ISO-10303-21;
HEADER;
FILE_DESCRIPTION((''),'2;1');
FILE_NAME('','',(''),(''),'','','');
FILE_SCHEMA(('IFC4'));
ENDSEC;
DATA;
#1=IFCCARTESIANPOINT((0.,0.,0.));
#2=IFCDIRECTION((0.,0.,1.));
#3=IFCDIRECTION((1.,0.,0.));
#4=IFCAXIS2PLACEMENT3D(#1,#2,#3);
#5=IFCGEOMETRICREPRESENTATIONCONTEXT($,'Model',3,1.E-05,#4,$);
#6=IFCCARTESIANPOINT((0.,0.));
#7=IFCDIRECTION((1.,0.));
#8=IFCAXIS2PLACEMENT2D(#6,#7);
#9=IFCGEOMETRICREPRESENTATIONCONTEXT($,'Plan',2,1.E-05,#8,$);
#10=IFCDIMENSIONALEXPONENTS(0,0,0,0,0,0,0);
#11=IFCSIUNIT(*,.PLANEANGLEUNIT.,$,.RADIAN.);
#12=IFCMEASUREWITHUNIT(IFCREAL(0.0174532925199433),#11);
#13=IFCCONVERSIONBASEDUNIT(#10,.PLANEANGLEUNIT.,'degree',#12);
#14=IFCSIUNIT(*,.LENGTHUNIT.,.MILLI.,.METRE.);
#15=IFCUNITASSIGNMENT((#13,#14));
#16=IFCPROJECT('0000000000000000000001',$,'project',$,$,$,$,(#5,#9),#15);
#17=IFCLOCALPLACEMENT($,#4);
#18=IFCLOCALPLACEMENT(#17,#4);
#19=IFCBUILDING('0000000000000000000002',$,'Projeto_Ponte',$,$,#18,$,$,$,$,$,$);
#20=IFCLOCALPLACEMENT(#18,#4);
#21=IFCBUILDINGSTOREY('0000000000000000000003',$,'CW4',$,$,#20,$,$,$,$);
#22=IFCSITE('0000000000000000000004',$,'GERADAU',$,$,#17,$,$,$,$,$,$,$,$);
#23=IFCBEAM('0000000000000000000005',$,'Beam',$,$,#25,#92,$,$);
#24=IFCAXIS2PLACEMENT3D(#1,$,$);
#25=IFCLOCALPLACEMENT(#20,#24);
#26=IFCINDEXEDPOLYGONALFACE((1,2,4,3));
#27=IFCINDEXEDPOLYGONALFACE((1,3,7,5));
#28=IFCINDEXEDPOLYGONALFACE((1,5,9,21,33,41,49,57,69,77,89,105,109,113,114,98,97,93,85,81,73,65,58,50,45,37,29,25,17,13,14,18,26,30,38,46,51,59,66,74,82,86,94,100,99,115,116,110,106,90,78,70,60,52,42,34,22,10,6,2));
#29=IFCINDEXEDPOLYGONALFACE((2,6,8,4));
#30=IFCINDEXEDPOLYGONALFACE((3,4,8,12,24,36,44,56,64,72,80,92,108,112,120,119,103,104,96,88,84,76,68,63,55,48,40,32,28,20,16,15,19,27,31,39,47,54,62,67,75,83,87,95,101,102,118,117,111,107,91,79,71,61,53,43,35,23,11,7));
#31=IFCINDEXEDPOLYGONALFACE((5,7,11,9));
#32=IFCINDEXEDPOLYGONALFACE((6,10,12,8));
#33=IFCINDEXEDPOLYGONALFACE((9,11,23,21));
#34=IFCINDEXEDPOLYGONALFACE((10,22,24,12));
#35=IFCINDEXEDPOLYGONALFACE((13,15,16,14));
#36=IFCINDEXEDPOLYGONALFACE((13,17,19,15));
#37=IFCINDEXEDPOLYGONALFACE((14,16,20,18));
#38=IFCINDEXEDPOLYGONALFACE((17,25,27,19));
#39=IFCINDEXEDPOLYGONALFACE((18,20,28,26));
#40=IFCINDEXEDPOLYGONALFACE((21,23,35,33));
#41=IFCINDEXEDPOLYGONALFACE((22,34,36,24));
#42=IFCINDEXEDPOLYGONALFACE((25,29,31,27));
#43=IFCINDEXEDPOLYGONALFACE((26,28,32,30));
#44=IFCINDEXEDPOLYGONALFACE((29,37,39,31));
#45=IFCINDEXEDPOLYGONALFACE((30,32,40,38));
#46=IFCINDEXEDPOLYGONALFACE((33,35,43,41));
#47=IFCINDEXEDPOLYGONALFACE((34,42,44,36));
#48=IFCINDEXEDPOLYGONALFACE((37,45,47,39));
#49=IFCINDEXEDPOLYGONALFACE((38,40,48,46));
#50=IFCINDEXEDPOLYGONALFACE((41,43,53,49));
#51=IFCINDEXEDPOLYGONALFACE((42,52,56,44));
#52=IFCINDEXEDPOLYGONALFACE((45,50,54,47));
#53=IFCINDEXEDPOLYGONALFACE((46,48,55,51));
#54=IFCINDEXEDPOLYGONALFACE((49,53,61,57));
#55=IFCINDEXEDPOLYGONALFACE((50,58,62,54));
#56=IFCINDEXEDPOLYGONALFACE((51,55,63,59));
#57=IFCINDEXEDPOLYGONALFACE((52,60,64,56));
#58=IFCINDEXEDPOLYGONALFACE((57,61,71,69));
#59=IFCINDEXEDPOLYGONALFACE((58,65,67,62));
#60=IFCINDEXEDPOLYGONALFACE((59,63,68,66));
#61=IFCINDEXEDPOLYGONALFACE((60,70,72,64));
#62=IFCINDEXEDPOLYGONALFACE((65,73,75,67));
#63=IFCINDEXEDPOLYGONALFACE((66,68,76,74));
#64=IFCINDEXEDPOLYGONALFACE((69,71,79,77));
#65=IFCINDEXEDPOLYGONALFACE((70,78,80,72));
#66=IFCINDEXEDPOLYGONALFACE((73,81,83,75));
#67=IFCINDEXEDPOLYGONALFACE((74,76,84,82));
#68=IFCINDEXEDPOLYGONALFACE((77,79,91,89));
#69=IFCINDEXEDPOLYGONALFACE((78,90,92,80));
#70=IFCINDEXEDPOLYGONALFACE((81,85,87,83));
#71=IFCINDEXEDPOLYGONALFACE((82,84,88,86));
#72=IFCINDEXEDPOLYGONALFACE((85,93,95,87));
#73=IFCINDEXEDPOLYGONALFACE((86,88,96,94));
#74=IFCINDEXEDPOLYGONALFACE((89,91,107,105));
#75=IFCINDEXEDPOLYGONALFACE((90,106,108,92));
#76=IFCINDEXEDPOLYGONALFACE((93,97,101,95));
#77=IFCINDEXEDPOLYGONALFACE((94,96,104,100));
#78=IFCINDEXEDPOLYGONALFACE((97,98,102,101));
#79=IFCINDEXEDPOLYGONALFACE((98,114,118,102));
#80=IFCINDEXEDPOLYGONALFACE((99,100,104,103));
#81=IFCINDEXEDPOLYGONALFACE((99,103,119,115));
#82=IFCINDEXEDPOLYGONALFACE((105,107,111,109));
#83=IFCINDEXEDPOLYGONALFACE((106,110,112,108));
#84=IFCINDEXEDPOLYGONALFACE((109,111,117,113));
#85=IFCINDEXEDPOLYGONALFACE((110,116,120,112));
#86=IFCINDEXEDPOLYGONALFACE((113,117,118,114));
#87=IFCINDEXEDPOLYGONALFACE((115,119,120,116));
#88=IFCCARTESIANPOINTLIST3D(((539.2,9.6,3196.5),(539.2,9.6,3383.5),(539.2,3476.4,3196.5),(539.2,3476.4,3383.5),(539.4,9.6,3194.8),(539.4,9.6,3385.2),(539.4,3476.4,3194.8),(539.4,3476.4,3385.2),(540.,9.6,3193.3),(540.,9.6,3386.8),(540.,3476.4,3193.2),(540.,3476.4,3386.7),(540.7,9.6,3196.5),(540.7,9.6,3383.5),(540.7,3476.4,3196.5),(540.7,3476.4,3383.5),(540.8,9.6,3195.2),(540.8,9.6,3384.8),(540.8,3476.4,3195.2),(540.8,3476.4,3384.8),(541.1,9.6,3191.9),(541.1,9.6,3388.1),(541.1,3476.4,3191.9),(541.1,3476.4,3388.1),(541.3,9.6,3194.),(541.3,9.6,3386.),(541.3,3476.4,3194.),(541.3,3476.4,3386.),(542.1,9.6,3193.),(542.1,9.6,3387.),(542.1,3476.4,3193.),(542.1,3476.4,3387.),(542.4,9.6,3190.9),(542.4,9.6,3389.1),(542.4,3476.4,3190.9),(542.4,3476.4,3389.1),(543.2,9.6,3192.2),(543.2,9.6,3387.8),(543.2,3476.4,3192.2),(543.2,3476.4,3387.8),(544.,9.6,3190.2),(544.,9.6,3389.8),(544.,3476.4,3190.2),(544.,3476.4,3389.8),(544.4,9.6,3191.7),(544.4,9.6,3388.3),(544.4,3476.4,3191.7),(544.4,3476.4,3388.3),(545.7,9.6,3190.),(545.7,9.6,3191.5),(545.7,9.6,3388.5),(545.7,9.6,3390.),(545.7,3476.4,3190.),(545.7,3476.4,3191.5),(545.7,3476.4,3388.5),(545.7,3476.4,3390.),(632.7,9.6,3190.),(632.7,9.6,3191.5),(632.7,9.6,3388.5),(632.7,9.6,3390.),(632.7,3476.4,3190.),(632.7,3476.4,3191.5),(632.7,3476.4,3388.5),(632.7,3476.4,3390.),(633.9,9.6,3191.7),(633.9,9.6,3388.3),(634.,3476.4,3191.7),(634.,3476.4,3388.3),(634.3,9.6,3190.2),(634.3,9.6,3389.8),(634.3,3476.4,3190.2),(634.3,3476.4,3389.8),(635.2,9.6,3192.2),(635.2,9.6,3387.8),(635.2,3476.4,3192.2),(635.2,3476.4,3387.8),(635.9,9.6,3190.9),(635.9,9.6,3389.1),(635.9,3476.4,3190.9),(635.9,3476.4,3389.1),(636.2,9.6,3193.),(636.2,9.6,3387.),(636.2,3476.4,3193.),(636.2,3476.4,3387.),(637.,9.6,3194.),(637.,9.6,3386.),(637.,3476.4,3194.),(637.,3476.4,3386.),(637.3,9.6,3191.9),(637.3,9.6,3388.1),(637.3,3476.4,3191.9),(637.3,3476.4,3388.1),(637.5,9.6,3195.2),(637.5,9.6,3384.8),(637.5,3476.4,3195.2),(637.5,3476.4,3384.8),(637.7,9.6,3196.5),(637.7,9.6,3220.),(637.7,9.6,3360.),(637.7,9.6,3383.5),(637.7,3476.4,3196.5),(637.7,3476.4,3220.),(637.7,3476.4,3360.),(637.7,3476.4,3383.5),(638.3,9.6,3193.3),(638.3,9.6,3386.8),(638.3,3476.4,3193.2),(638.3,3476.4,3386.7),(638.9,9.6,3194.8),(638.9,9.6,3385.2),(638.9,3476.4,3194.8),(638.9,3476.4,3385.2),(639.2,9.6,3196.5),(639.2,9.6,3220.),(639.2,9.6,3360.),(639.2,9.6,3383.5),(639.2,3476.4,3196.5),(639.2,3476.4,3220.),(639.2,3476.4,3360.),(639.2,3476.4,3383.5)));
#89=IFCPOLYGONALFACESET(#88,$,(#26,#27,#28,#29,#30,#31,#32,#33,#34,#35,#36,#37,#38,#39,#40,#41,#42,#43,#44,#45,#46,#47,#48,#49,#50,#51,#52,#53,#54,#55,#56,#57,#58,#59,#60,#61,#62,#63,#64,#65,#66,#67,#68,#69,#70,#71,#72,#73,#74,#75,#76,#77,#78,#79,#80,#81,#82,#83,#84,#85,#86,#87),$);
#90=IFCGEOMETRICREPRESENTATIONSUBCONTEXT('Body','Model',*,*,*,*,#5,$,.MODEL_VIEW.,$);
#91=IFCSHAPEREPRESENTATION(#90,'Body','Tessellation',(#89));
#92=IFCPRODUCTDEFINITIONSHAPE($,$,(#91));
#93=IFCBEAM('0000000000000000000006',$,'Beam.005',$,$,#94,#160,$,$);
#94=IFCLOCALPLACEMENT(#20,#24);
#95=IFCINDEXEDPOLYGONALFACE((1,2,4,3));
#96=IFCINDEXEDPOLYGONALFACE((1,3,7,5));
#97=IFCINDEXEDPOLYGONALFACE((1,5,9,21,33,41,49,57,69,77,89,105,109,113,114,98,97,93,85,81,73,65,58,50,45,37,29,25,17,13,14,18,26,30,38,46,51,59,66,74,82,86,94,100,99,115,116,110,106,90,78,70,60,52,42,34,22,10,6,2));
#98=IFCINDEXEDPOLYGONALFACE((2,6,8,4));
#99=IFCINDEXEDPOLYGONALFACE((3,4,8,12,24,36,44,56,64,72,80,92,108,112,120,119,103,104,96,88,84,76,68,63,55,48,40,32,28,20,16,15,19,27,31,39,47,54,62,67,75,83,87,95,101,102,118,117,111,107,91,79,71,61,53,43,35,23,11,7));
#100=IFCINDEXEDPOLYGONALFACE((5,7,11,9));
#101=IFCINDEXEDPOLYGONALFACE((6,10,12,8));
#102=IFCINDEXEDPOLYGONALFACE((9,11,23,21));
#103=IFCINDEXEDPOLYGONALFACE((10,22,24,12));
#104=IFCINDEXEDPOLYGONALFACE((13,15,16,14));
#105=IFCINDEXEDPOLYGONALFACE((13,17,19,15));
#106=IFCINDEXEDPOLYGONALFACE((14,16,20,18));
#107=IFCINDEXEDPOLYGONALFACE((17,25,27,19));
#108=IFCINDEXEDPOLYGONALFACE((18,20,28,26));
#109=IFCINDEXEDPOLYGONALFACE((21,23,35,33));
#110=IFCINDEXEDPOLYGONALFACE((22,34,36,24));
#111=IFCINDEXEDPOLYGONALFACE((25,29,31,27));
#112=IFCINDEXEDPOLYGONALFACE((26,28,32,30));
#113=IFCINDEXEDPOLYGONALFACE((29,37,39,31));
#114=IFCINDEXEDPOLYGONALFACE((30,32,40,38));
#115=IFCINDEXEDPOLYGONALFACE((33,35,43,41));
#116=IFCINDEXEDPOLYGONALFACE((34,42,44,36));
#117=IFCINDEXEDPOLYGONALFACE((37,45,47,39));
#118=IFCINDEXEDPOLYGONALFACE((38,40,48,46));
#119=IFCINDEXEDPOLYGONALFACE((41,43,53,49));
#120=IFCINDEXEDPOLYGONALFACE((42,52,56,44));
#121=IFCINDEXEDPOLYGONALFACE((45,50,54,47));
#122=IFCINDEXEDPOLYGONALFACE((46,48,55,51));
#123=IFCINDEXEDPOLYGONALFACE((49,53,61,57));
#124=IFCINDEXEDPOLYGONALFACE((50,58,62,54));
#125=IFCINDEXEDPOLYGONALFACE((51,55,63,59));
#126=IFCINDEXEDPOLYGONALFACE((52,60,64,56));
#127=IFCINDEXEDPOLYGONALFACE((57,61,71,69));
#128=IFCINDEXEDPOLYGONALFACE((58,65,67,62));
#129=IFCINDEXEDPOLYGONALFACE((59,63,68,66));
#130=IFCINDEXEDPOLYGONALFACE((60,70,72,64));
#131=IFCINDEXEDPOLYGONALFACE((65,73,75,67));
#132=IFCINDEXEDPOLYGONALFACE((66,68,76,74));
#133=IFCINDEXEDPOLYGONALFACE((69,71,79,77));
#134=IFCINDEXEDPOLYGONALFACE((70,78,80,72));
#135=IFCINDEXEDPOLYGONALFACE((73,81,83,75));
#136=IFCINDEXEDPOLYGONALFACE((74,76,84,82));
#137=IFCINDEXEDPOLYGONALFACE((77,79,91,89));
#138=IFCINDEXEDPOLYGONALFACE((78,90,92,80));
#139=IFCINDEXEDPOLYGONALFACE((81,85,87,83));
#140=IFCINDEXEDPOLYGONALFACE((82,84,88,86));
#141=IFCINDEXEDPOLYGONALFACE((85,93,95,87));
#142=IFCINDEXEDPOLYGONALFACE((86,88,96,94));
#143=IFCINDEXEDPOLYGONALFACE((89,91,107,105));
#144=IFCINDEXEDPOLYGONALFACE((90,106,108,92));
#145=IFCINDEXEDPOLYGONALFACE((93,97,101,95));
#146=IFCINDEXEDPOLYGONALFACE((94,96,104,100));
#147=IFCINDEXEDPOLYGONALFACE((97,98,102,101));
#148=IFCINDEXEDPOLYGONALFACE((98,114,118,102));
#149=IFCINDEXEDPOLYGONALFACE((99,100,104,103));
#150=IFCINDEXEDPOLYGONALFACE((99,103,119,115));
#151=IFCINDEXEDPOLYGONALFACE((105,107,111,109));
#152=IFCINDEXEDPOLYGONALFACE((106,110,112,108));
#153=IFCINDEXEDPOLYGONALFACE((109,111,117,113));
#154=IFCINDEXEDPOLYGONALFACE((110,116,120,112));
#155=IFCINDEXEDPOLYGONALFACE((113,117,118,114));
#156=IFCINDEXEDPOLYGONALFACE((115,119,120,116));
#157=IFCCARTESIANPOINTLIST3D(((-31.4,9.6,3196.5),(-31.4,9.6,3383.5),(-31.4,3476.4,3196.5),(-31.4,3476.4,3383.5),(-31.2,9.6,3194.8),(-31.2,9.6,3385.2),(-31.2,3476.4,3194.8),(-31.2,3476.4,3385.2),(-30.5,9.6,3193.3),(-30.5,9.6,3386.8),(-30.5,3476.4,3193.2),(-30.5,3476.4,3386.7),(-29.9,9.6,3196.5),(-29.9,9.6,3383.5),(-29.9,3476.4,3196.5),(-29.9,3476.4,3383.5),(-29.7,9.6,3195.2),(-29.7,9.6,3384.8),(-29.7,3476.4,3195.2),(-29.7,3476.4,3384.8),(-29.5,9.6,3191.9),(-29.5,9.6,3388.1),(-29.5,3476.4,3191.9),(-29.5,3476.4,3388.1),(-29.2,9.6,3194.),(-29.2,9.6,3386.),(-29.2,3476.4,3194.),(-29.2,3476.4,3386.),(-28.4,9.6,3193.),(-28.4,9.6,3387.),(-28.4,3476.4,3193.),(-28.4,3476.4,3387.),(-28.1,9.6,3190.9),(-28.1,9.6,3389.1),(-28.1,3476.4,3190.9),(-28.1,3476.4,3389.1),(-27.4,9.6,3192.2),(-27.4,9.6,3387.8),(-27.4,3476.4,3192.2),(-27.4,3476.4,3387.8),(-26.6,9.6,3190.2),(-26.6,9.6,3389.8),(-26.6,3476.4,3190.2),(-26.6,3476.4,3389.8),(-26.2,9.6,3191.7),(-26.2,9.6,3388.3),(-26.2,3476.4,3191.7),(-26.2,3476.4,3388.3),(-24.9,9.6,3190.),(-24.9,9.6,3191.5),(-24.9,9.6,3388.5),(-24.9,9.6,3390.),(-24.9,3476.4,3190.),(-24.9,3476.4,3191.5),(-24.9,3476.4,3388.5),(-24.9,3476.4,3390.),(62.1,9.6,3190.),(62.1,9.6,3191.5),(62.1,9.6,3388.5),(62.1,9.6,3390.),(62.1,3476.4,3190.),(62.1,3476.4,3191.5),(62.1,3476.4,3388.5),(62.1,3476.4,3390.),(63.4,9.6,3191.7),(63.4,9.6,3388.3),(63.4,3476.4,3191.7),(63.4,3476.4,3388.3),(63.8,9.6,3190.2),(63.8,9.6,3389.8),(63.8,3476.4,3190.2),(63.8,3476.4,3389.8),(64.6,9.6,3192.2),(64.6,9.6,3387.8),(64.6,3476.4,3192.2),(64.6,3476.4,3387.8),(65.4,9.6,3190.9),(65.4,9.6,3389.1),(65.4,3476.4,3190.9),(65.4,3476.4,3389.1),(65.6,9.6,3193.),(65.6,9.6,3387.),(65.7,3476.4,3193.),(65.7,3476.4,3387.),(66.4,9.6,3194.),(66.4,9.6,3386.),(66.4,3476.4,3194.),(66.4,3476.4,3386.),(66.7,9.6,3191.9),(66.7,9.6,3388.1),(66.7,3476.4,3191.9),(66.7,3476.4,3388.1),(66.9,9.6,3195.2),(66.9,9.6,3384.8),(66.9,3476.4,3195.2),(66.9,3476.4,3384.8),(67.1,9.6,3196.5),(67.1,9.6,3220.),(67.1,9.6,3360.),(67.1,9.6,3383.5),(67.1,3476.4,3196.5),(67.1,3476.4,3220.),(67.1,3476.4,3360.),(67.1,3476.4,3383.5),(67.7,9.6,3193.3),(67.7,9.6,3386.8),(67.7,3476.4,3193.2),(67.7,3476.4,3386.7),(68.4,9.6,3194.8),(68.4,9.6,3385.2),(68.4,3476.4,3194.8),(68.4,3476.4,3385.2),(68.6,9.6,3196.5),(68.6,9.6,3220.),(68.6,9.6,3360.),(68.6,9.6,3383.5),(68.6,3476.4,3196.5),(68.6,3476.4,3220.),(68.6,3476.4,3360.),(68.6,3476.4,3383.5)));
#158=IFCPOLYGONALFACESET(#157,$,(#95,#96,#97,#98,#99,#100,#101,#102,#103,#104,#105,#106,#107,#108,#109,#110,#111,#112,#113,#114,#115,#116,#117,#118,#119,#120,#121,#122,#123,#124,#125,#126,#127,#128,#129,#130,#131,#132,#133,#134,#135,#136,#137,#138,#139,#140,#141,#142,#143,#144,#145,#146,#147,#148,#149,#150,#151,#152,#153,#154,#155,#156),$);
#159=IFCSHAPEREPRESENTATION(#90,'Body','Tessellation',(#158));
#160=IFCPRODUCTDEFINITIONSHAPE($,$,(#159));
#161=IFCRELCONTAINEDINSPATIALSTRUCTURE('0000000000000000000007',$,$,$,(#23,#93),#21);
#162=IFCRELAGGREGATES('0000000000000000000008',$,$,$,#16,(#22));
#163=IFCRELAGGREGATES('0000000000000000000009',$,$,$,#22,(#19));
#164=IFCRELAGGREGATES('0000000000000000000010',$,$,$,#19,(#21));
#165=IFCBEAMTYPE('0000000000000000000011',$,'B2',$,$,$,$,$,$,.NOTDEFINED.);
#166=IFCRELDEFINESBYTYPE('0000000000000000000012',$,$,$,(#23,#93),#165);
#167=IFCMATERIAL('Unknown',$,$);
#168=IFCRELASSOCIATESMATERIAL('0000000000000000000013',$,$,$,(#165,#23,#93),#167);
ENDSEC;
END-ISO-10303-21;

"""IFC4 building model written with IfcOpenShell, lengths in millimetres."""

from ifc_helpers import new_model, entity, si_unit, converted_unit, frame, origin_with_axes, origin_2d_with_axis, place, context, subcontext, project, spatial, c_section, extrude, material, material_profile, profile_set, profile_usage, type_object, element, save


model = new_model("IFC4")

# Units and contexts
model_context = context("Model", 3, precision=1e-05, world=origin_with_axes())
plan_context = context("Plan", 2, precision=1e-05, world=origin_2d_with_axis())
body_context = subcontext(model_context, "Body", "Model", "MODEL_VIEW")
ifc_project = project(units=[converted_unit("PLANEANGLEUNIT", "degree", entity("IfcReal", 0.0174532925199433), si_unit("PLANEANGLEUNIT", "RADIAN"), dimensions=[0, 0, 0, 0, 0, 0, 0]), si_unit("LENGTHUNIT", "METRE", prefix="MILLI")], contexts=[model_context, plan_context])

# Site, building, storey
site_placement = place(None, origin_with_axes())
site = spatial("IfcSite", under=ifc_project, at=site_placement, Name="GERADAU")
building_placement = place(site_placement, origin_with_axes())
building = spatial("IfcBuilding", under=site, at=building_placement, Name="Projeto_Ponte")
storey_placement = place(building_placement, origin_with_axes())
storey = spatial("IfcBuildingStorey", under=building, at=storey_placement, Name="CW4")

# Beams
ifc_material = material(Name="Unknown")
ifc_material_profile = material_profile(ifc_material, c_section(Depth=200.0, Width=100.0, WallThickness=1.5, Girth=30.0, InternalFilletRadius=5.0))
ifc_profile_set = profile_set([ifc_material_profile])
beam_type = type_object("IfcBeamType", Name="B2", PredefinedType="NOTDEFINED", material=ifc_profile_set)
ifc_profile_usage_1 = profile_usage(ifc_profile_set, cardinal=5)
beam_1_placement = place(storey_placement, frame((589.2, 3476.4, 3290.0), z_axis=(0.0, -1.0, 0.0), x_axis=(1.0, 0.0, 0.0)))
element("IfcBeam", 1, at=beam_1_placement, inside=storey, type_object=beam_type, material=ifc_profile_usage_1, Name="Beam", context=body_context, shape_type="SweptSolid", body=[
    extrude(c_section(Depth=200.0, Width=100.0, WallThickness=1.5, Girth=30.0, InternalFilletRadius=5.0), origin_with_axes(), (0.0, 0.0, 1.0), 3466.8),
])
ifc_profile_usage_2 = profile_usage(ifc_profile_set, cardinal=5)
beam_2_placement = place(storey_placement, frame((18.6, 3476.4, 3290.0), z_axis=(0.0, -1.0, 0.0), x_axis=(1.0, 0.0, 0.0)))
element("IfcBeam", 2, at=beam_2_placement, inside=storey, type_object=beam_type, material=ifc_profile_usage_2, Name="Beam.005", context=body_context, shape_type="SweptSolid", body=[
    extrude(c_section(Depth=200.0, Width=100.0, WallThickness=1.5, Girth=30.0, InternalFilletRadius=5.0), origin_with_axes(), (0.0, 0.0, 1.0), 3466.8),
])

save(model, "model.ifc")
